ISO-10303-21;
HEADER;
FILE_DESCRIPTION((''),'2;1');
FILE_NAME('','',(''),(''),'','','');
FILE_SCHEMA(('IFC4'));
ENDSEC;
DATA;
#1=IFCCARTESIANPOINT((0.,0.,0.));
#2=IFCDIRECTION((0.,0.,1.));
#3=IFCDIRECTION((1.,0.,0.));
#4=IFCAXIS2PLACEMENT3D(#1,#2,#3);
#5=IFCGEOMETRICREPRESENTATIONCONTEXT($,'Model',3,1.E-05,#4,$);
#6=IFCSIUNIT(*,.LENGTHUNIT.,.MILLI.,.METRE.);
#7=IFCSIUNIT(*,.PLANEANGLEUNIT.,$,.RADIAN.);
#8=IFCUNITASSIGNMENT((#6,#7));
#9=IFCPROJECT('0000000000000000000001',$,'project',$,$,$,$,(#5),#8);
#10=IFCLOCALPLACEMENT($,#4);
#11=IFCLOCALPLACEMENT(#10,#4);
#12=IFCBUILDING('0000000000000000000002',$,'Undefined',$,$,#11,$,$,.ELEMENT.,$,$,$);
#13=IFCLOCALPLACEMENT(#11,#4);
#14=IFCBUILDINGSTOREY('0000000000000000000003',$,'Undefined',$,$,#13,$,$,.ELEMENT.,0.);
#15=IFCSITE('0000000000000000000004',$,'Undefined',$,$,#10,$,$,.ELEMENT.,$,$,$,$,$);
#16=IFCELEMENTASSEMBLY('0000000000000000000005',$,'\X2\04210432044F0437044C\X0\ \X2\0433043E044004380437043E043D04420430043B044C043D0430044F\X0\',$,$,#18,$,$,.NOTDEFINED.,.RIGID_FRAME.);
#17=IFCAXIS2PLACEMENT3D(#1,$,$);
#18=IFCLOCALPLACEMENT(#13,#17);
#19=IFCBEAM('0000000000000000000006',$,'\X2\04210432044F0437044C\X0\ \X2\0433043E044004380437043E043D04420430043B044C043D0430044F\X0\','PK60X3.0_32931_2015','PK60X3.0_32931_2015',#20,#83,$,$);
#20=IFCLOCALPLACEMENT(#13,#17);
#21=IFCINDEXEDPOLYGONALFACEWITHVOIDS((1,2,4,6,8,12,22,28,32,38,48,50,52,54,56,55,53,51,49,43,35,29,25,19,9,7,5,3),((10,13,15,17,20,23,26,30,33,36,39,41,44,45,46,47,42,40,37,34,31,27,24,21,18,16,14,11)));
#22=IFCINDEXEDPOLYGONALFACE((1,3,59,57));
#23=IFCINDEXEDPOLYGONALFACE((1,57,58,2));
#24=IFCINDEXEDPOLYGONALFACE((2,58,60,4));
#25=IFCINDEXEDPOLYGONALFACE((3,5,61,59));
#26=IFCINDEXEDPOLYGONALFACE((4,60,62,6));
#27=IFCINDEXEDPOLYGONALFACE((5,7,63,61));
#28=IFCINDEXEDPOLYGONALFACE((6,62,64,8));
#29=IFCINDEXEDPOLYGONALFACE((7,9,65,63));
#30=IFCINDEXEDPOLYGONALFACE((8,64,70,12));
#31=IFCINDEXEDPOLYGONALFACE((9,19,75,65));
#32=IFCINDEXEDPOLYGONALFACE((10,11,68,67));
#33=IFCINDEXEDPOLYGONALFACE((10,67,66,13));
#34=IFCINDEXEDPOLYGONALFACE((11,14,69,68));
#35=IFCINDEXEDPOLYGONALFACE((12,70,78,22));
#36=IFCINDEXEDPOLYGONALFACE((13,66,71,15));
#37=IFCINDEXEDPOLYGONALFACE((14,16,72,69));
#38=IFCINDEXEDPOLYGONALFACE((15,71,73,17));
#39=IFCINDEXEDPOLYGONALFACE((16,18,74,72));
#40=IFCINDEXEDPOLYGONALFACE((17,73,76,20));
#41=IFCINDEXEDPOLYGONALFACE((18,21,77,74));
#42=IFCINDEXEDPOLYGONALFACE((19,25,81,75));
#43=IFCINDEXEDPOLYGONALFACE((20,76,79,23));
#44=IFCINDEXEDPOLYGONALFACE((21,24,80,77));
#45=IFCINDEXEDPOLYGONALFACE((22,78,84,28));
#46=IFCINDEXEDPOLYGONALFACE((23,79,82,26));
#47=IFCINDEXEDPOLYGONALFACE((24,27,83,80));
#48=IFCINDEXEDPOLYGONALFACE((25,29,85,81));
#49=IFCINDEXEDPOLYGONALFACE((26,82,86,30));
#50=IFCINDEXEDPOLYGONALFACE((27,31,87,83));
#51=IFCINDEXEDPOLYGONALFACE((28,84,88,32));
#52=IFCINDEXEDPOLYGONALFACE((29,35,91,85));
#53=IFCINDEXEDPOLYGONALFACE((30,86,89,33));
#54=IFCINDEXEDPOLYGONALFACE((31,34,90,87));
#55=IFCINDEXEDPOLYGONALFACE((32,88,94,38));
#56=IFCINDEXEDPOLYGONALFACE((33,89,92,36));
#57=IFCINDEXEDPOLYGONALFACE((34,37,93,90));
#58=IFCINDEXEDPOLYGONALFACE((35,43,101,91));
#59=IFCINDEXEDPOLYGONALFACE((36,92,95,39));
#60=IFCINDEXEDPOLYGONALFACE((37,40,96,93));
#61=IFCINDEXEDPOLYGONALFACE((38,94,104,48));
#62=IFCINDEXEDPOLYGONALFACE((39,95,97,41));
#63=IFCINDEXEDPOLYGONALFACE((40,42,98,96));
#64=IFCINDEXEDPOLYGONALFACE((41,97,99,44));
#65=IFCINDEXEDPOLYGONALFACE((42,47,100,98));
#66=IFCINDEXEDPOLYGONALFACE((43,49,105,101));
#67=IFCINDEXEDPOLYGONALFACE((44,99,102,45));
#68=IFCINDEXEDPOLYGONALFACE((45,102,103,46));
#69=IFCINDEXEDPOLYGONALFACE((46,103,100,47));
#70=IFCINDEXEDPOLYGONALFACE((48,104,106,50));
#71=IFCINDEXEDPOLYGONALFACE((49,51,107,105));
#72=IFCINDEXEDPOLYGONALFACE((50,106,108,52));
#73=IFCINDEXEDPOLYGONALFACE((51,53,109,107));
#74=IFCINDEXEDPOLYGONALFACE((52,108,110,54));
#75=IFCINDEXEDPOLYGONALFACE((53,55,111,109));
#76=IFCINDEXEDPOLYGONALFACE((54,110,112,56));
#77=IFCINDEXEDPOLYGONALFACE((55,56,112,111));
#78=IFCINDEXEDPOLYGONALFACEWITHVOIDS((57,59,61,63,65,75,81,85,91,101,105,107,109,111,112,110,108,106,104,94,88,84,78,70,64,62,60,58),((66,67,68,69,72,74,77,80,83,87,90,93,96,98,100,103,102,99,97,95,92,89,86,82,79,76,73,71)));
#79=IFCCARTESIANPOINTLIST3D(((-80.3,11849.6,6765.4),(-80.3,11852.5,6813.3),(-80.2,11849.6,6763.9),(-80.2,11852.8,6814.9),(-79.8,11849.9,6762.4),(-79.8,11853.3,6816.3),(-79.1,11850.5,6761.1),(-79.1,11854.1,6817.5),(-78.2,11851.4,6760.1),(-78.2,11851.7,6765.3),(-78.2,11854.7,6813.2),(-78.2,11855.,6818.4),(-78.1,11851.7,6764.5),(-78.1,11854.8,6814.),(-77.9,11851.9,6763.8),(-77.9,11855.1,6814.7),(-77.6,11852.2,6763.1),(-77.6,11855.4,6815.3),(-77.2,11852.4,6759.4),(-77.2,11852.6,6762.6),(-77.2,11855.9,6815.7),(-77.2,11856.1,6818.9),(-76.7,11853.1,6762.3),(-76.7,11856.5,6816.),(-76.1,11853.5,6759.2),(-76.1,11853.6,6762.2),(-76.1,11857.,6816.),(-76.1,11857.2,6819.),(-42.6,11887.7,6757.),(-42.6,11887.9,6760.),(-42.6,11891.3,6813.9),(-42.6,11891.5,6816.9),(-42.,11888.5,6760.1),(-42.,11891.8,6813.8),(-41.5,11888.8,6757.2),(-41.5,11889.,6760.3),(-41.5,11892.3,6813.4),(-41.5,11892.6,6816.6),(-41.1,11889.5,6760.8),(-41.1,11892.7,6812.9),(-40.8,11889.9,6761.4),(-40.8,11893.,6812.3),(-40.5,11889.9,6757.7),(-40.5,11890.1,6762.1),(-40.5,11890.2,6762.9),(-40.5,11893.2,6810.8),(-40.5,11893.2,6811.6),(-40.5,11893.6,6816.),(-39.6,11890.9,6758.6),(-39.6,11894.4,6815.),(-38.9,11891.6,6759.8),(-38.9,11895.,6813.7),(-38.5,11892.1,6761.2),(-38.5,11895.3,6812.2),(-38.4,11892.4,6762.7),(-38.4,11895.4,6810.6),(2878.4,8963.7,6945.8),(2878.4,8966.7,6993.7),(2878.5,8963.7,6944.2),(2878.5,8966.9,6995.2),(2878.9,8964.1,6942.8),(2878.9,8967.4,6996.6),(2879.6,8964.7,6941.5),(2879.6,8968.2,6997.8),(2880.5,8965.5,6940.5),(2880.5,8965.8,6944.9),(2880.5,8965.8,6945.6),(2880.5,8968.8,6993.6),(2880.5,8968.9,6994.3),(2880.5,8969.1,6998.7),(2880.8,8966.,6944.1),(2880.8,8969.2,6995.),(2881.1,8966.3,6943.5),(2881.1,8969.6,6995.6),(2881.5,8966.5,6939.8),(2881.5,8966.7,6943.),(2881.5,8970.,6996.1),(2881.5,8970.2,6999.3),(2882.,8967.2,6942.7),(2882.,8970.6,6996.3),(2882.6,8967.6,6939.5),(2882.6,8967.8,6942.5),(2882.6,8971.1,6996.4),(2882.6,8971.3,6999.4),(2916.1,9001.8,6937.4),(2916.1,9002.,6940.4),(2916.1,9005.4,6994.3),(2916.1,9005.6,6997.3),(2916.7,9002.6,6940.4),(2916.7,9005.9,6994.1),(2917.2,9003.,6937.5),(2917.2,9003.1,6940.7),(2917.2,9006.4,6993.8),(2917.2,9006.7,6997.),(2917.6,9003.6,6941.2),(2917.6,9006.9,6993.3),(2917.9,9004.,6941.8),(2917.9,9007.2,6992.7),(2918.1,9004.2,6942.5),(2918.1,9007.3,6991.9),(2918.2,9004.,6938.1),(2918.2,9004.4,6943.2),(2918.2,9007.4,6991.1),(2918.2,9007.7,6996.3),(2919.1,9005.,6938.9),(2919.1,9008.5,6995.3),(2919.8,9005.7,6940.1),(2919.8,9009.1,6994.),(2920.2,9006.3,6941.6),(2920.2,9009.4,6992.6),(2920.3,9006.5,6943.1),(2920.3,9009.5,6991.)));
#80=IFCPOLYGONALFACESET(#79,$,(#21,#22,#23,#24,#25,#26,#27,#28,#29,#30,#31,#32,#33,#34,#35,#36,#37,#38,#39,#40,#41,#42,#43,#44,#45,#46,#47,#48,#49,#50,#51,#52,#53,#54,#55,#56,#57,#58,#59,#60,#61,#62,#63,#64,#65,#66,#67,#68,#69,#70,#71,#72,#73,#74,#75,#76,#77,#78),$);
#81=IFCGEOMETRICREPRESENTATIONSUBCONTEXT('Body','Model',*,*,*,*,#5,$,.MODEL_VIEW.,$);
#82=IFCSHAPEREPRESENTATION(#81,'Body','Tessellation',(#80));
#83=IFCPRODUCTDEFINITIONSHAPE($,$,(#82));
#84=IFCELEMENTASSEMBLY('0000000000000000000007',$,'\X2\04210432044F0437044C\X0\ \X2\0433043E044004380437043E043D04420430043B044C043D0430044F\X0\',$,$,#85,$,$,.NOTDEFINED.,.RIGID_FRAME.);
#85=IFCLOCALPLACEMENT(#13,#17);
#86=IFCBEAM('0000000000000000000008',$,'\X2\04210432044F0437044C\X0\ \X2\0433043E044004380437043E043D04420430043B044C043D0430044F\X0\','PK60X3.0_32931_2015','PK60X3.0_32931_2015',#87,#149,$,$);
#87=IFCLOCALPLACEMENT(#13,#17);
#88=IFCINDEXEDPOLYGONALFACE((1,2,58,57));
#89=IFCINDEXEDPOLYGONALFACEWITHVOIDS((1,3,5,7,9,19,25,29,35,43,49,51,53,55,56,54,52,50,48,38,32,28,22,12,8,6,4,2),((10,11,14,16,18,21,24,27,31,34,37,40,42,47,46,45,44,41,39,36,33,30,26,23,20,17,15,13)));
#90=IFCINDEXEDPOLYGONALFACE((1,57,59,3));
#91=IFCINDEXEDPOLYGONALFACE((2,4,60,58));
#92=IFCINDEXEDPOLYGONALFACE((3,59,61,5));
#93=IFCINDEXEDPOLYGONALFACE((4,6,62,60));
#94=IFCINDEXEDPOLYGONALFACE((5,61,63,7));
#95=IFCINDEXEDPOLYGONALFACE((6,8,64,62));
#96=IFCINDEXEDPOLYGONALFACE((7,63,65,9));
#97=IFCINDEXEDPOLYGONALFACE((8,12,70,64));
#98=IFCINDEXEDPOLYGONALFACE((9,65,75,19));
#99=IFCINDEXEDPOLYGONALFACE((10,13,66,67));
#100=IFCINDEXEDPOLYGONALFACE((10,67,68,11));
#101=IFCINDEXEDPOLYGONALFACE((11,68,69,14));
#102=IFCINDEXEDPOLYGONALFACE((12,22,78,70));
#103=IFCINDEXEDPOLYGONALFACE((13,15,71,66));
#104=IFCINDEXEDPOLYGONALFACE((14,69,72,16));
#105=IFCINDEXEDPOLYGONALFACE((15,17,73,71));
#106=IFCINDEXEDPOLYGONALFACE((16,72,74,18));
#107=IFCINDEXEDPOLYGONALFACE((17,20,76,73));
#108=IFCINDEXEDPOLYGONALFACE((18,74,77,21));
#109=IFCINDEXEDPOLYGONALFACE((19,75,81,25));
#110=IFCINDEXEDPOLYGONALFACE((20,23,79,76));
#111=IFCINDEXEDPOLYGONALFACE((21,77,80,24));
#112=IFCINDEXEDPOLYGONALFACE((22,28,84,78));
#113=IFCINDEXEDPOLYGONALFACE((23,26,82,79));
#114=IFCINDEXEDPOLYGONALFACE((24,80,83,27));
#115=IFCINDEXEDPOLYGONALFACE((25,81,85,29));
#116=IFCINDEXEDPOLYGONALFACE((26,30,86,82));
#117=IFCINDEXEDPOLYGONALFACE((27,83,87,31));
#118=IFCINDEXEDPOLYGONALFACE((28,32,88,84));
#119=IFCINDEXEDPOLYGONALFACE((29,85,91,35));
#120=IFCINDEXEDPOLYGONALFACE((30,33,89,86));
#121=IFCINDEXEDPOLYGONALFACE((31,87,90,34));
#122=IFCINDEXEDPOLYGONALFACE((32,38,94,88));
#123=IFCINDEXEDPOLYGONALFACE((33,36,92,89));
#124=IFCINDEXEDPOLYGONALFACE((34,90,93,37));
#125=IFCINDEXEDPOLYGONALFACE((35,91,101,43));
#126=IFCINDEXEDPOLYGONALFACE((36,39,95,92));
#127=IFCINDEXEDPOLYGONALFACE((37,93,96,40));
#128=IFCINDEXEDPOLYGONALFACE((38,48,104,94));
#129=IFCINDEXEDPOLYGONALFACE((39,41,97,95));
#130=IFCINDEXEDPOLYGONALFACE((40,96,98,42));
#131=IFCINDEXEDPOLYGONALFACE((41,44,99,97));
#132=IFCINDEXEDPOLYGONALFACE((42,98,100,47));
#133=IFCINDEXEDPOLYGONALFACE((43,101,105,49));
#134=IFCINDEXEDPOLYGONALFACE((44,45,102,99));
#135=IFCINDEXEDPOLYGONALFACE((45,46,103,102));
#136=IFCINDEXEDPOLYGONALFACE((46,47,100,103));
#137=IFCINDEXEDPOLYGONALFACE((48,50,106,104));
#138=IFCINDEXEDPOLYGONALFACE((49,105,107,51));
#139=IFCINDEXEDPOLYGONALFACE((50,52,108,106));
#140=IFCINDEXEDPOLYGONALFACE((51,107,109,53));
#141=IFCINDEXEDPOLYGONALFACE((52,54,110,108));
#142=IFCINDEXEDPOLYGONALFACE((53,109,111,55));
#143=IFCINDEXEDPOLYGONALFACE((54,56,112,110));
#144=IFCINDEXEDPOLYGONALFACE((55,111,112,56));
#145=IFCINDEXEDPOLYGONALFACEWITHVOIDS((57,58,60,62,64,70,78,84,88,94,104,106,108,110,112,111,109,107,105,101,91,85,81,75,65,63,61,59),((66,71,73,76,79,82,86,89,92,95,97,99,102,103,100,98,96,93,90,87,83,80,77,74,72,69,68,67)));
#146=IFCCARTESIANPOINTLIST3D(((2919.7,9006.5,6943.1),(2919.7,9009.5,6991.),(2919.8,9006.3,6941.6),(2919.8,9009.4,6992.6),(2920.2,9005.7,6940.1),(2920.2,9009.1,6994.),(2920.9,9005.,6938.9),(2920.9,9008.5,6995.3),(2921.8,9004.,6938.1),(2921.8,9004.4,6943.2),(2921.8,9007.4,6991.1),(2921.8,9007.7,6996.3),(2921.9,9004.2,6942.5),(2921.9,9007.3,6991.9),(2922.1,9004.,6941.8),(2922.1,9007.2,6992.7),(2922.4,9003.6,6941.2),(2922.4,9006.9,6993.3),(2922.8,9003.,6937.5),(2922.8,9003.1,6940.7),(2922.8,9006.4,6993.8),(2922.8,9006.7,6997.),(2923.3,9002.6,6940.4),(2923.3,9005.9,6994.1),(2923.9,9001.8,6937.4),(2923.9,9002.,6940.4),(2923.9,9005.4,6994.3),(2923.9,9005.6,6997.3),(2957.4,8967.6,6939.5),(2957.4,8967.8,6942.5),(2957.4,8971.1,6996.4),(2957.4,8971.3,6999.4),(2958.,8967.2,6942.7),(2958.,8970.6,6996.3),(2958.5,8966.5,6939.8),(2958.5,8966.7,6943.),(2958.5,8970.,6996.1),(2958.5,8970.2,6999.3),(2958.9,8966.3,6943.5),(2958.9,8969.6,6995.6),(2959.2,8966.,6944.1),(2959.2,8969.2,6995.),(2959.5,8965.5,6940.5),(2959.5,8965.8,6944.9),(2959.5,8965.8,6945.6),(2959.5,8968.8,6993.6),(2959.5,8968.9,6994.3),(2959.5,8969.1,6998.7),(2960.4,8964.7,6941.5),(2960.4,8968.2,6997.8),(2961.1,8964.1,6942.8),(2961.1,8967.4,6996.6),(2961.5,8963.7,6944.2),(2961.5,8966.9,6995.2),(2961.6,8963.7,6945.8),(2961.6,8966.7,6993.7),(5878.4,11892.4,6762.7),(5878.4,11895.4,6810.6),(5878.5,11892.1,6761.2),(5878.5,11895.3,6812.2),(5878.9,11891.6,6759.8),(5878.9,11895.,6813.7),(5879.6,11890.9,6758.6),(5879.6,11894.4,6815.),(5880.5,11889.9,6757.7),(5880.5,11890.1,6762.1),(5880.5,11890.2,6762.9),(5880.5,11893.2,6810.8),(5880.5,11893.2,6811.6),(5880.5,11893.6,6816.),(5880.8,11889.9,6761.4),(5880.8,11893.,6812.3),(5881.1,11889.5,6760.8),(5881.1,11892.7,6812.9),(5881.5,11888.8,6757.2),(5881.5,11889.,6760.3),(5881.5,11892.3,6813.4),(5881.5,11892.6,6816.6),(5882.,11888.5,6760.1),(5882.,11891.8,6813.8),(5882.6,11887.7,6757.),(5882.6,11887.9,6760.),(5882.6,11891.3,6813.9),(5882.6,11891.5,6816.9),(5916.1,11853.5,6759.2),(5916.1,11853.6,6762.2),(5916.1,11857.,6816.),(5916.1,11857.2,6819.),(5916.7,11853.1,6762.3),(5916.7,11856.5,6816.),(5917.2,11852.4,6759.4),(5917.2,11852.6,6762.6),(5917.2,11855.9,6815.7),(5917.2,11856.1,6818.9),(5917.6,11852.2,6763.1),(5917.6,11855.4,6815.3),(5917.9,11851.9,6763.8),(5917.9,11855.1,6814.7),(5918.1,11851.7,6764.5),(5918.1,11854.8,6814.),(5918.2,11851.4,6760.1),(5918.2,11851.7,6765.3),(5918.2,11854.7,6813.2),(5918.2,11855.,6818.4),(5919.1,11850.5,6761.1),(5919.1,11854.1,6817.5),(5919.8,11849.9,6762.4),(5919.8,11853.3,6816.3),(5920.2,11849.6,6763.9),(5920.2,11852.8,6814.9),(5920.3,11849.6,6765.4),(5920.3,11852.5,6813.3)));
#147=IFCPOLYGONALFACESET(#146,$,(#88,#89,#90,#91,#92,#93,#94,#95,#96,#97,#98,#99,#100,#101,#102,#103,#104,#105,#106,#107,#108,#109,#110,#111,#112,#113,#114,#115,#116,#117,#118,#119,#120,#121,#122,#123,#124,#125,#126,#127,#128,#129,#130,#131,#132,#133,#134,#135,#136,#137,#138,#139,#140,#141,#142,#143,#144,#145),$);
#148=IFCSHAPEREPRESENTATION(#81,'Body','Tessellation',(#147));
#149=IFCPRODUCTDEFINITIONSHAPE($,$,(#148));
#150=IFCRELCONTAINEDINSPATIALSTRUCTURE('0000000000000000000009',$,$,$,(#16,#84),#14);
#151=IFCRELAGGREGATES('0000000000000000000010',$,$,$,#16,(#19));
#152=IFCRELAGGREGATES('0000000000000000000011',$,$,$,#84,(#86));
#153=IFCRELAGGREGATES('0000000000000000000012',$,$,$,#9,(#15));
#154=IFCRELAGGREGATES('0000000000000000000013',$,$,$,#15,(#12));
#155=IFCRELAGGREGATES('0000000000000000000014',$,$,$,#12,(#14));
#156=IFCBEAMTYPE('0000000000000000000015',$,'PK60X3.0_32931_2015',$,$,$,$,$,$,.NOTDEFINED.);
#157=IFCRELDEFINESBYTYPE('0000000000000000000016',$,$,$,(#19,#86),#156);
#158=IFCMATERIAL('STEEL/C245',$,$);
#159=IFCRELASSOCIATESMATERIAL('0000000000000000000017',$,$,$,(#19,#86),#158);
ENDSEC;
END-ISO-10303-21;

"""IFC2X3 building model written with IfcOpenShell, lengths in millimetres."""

from ifc_helpers import new_model, si_unit, frame, origin_with_axes, origin_2d_with_axis, place, context, subcontext, project, spatial, hollow_rectangle, extrude, material, type_object, element, aggregate, save


model = new_model("IFC2X3")

# Units and contexts
model_context = context("Model", 3, precision=1e-05, world=origin_with_axes())
body_context = subcontext(model_context, "Body", "Model", "MODEL_VIEW")
ifc_project = project(units=[si_unit("LENGTHUNIT", "METRE", prefix="MILLI"), si_unit("PLANEANGLEUNIT", "RADIAN")], contexts=[model_context])

# Site, building, storey
site_placement = place(None, origin_with_axes())
site = spatial("IfcSite", under=ifc_project, at=site_placement, Name="Undefined", CompositionType="ELEMENT")
building_placement = place(site_placement, origin_with_axes())
building = spatial("IfcBuilding", under=site, at=building_placement, Name="Undefined", CompositionType="ELEMENT")
storey_placement = place(building_placement, origin_with_axes())
storey = spatial("IfcBuildingStorey", under=building, at=storey_placement, Name="Undefined", CompositionType="ELEMENT", Elevation=0.0)

# Shared definitions
ifc_material = material(Name="STEEL/C245")

# Element assemblies, beams
assembly_1_placement = place(storey_placement, origin_with_axes())
assembly_1 = element("IfcElementAssembly", 1, at=assembly_1_placement, inside=storey, Name="Связь горизонтальная", AssemblyPlace="NOTDEFINED", PredefinedType="RIGID_FRAME")
beam_type_1 = type_object("IfcBeamType", Name="PK60X3.0_32931_2015", PredefinedType="NOTDEFINED")
beam_1_placement = place(assembly_1_placement, frame((-59.3, 11872.5, 6788.0), z_axis=(0.0, 0.062378, 0.998053), x_axis=(0.715179, -0.69758, 0.043599)))
beam_1 = element("IfcBeam", 2, at=beam_1_placement, type_object=beam_type_1, material=ifc_material, Name="Связь горизонтальная", Description="PK60X3.0_32931_2015", ObjectType="PK60X3.0_32931_2015", context=body_context, shape_type="SweptSolid", body=[
    extrude(hollow_rectangle(XDim=60.0, YDim=60.0, WallThickness=3.0, InnerFilletRadius=3.0, OuterFilletRadius=6.0, at=origin_2d_with_axis()), frame((4137.0, 0.0, 0.0), z_axis=(-1.0, 0.0, 0.0), x_axis=(0.0, -1.0, 0.0)), (0.0, 0.0, 1.0), 4137.0),
])
aggregate(assembly_1, [beam_1])
assembly_2_placement = place(storey_placement, origin_with_axes())
assembly_2 = element("IfcElementAssembly", 3, at=assembly_2_placement, inside=storey, Name="Связь горизонтальная", AssemblyPlace="NOTDEFINED", PredefinedType="RIGID_FRAME")
beam_2_placement = place(assembly_2_placement, frame((5899.3, 11872.5, 6788.0), z_axis=(0.0, 0.062378, 0.998053), x_axis=(-0.715179, -0.69758, 0.043599)))
beam_2 = element("IfcBeam", 4, at=beam_2_placement, type_object=beam_type_1, material=ifc_material, Name="Связь горизонтальная", Description="PK60X3.0_32931_2015", ObjectType="PK60X3.0_32931_2015", context=body_context, shape_type="SweptSolid", body=[
    extrude(hollow_rectangle(XDim=60.0, YDim=60.0, WallThickness=3.0, InnerFilletRadius=3.0, OuterFilletRadius=6.0, at=origin_2d_with_axis()), frame((4137.0, 0.0, 0.0), z_axis=(-1.0, 0.0, 0.0), x_axis=(0.0, -1.0, 0.0)), (0.0, 0.0, 1.0), 4137.0),
])
aggregate(assembly_2, [beam_2])

save(model, "model.ifc")
